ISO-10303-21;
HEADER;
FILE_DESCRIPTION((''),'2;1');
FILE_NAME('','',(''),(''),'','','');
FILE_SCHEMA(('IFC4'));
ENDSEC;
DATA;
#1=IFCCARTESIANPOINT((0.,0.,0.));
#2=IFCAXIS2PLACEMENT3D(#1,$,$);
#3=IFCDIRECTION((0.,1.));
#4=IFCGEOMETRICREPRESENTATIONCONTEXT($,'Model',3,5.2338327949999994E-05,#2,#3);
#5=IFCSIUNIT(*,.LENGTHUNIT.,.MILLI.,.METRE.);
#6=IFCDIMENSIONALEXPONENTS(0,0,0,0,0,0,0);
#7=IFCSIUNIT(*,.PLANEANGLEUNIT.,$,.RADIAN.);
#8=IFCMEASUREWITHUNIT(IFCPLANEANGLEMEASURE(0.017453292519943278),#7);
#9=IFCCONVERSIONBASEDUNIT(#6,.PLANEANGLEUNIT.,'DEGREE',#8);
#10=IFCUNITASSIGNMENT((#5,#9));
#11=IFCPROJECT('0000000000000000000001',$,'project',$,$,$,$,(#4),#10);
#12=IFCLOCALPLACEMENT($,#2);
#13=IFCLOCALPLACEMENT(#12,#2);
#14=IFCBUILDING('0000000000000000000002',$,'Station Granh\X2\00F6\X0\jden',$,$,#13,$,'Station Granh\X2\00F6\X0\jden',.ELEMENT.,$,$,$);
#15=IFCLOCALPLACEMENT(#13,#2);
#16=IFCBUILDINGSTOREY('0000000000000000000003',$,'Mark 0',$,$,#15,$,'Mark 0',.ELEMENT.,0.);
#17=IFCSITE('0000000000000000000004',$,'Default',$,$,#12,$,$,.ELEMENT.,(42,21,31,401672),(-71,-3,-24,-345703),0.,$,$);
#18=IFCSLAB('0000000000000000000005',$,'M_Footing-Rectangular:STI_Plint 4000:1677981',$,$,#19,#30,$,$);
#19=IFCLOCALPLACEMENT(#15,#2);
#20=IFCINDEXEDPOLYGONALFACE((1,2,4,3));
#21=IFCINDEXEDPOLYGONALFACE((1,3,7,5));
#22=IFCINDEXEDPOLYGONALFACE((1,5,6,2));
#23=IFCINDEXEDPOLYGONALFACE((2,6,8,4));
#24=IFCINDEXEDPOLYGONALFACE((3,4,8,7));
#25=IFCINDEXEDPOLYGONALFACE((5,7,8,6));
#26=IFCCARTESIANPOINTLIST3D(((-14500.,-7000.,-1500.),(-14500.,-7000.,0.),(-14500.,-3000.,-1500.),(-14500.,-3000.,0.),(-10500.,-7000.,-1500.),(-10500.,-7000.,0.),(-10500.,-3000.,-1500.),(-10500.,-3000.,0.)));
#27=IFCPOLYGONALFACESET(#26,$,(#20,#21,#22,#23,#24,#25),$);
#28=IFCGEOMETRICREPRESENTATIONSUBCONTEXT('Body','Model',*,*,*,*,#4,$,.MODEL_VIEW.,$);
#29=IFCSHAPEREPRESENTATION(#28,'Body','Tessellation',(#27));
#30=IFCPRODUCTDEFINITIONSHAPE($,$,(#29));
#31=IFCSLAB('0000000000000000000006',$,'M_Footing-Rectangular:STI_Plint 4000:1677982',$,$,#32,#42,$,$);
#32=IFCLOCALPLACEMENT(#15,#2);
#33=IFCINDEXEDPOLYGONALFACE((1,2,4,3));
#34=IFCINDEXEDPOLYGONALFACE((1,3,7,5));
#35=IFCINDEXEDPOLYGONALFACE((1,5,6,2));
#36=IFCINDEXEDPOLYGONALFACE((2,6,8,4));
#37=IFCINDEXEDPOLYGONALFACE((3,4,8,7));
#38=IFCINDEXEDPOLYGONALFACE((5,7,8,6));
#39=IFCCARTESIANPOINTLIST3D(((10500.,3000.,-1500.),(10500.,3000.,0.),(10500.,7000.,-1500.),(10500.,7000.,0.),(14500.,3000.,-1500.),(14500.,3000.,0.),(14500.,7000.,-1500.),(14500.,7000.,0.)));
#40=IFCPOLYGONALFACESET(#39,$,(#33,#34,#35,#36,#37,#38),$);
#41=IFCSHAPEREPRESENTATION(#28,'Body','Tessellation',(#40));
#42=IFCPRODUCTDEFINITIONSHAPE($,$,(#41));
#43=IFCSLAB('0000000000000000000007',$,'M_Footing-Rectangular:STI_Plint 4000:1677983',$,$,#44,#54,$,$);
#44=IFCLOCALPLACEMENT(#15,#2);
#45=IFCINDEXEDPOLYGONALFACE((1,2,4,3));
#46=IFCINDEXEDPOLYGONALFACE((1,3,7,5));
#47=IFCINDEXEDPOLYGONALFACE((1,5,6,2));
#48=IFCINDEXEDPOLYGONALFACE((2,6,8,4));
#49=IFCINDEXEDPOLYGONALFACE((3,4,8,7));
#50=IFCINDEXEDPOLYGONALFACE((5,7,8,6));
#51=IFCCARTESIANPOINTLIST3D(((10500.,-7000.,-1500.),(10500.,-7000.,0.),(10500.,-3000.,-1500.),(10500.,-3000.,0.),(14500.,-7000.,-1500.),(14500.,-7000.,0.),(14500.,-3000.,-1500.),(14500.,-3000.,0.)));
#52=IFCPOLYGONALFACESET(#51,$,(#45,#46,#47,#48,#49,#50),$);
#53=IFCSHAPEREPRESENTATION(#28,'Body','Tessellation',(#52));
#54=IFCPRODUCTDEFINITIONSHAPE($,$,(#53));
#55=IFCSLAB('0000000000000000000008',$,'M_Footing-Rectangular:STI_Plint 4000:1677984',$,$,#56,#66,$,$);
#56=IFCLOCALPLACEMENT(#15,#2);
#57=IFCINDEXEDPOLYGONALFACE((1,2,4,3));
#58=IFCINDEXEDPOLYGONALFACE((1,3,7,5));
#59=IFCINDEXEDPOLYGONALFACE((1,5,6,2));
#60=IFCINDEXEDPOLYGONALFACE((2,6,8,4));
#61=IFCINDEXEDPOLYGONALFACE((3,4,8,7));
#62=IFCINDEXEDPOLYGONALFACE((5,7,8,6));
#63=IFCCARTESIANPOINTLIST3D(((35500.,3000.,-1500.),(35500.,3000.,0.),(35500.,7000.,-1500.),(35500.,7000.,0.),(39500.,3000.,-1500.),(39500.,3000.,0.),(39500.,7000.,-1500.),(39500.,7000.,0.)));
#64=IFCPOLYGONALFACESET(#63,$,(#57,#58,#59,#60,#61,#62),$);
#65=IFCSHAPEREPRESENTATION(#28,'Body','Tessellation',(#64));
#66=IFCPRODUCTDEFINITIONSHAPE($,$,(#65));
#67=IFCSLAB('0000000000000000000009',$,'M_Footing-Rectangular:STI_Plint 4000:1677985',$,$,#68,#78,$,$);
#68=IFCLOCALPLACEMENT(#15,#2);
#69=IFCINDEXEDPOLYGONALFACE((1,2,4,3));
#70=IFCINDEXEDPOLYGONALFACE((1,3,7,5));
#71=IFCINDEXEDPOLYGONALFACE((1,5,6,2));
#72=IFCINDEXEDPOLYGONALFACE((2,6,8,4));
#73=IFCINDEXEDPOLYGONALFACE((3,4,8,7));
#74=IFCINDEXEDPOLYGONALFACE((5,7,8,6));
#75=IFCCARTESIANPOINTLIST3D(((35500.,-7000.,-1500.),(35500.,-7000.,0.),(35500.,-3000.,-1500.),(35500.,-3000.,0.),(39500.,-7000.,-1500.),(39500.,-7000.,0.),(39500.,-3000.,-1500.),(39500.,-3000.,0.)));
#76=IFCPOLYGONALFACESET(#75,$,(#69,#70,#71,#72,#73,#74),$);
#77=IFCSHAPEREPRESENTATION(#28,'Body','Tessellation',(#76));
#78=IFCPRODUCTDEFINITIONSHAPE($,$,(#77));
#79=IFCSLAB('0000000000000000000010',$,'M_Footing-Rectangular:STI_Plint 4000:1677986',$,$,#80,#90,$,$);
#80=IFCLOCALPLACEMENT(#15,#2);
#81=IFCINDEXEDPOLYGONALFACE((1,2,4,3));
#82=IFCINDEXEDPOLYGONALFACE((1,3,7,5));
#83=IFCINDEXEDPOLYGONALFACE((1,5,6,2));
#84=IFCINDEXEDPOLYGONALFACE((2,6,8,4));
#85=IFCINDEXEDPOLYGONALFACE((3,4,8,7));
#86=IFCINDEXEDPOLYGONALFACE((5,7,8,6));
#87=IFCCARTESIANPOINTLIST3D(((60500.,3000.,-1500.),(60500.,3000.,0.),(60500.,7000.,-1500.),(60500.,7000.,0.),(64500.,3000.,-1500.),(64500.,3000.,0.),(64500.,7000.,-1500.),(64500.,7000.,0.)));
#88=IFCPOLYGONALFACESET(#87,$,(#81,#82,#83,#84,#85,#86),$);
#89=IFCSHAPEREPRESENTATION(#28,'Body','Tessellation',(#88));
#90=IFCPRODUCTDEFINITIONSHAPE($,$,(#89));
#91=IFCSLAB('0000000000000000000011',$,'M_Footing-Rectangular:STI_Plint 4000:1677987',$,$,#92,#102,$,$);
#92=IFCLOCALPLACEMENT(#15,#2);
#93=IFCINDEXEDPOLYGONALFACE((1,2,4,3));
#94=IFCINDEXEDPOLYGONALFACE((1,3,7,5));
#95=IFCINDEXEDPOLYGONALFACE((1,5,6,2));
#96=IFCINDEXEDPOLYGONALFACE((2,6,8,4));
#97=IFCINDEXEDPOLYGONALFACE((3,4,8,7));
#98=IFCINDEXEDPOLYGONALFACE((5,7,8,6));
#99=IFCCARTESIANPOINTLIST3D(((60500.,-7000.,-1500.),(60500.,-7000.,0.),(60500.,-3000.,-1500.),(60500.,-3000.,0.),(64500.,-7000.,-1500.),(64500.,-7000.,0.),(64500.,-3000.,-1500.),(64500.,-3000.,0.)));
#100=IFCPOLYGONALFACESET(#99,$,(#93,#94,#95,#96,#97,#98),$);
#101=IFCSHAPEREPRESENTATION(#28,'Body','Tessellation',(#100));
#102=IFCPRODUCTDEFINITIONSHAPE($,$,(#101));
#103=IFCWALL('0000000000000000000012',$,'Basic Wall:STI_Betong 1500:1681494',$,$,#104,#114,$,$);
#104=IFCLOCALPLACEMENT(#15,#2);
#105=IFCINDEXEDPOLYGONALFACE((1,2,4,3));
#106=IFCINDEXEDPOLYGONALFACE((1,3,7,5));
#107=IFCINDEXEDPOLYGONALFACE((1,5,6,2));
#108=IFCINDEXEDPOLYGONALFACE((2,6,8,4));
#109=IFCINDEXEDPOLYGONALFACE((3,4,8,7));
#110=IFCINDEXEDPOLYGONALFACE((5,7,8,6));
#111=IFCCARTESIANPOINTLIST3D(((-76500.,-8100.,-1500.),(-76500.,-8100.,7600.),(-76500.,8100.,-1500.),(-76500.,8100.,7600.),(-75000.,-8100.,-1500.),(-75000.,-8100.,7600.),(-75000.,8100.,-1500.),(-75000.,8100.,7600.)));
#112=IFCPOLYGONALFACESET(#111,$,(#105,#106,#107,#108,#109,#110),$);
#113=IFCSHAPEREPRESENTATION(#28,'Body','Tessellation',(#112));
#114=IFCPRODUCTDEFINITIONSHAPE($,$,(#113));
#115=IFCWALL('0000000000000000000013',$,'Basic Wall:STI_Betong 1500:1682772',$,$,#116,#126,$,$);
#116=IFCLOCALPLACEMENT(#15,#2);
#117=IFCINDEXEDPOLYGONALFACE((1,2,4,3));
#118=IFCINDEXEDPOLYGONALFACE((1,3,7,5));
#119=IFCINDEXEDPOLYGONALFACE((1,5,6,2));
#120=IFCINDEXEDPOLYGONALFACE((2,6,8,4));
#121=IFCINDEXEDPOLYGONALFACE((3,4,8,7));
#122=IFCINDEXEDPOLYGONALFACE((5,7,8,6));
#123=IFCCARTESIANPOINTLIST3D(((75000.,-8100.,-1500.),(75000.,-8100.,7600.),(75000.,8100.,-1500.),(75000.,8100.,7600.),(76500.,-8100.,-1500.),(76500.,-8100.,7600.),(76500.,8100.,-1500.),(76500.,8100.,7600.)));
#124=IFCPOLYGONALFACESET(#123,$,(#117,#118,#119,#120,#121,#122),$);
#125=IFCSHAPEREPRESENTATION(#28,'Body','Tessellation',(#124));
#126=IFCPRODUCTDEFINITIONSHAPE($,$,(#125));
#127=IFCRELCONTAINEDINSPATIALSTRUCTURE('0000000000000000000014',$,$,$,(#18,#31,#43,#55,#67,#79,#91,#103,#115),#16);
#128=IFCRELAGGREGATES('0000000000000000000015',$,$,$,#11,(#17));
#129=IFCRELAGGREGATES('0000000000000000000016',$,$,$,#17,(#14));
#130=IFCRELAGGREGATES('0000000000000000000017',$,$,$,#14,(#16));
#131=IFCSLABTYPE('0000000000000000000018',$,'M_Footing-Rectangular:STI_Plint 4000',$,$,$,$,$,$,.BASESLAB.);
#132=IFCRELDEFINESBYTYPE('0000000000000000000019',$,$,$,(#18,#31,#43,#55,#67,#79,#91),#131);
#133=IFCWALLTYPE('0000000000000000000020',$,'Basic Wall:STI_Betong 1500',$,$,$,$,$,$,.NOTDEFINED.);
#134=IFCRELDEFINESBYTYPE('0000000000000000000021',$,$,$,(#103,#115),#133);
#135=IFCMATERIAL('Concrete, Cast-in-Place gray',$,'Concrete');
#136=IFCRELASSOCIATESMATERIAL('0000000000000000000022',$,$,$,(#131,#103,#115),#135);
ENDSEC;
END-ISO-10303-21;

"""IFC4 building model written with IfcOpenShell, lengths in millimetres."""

from ifc_helpers import new_model, entity, si_unit, converted_unit, direction, frame, origin, place, context, subcontext, project, spatial, indexed_curve, outline, extrude, material, type_object, element, save


model = new_model("IFC4")

# Units and contexts
model_context = context("Model", 3, precision=5.2338327949999994e-05, world=origin(), true_north=direction((0.0, 1.0)))
body_context = subcontext(model_context, "Body", "Model", "MODEL_VIEW")
ifc_project = project(units=[si_unit("LENGTHUNIT", "METRE", prefix="MILLI"), converted_unit("PLANEANGLEUNIT", "DEGREE", entity("IfcPlaneAngleMeasure", 0.017453292519943278), si_unit("PLANEANGLEUNIT", "RADIAN"), dimensions=[0, 0, 0, 0, 0, 0, 0])], contexts=[model_context])

# Site, building, storey
site_placement = place(None, origin())
site = spatial("IfcSite", under=ifc_project, at=site_placement, Name="Default", CompositionType="ELEMENT", RefLatitude=(42, 21, 31, 401672), RefLongitude=(-71, -3, -24, -345703), RefElevation=0.0)
building_placement = place(site_placement, origin())
building = spatial("IfcBuilding", under=site, at=building_placement, Name="Station Granhöjden", LongName="Station Granhöjden", CompositionType="ELEMENT")
storey_placement = place(building_placement, origin())
storey = spatial("IfcBuildingStorey", under=building, at=storey_placement, Name="Mark 0", LongName="Mark 0", CompositionType="ELEMENT", Elevation=0.0)

# Shared definitions
ifc_material = material(Name="Concrete, Cast-in-Place gray", Category="Concrete")

# Slabs
slab_type = type_object("IfcSlabType", Name="M_Footing-Rectangular:STI_Plint 4000", PredefinedType="BASESLAB", material=ifc_material)
slab_1_placement = place(storey_placement, origin())
element("IfcSlab", 1, at=slab_1_placement, inside=storey, type_object=slab_type, Name="M_Footing-Rectangular:STI_Plint 4000:1677981", context=body_context, shape_type="SweptSolid", body=[
    extrude(outline(indexed_curve([(-2000.0, -2000.0), (2000.0, -2000.0), (2000.0, 2000.0), (-2000.0, 2000.0), (-2000.0, -2000.0)], self_intersect=False)), frame((-12500.0, -5000.0, -1500.0), z_axis=(0.0, 0.0, 1.0), x_axis=(-1.0, 0.0, 0.0)), (0.0, 0.0, 1.0), 1500.0),
])
slab_2_placement = place(storey_placement, origin())
element("IfcSlab", 2, at=slab_2_placement, inside=storey, type_object=slab_type, Name="M_Footing-Rectangular:STI_Plint 4000:1677982", context=body_context, shape_type="SweptSolid", body=[
    extrude(outline(indexed_curve([(-2000.0, -2000.0), (2000.0, -2000.0), (2000.0, 2000.0), (-2000.0, 2000.0), (-2000.0, -2000.0)], self_intersect=False)), frame((12500.0, 5000.0, -1500.0), z_axis=(0.0, 0.0, 1.0), x_axis=(-1.0, 0.0, 0.0)), (0.0, 0.0, 1.0), 1500.0),
])
slab_3_placement = place(storey_placement, origin())
element("IfcSlab", 3, at=slab_3_placement, inside=storey, type_object=slab_type, Name="M_Footing-Rectangular:STI_Plint 4000:1677983", context=body_context, shape_type="SweptSolid", body=[
    extrude(outline(indexed_curve([(-2000.0, -2000.0), (2000.0, -2000.0), (2000.0, 2000.0), (-2000.0, 2000.0), (-2000.0, -2000.0)], self_intersect=False)), frame((12500.0, -5000.0, -1500.0), z_axis=(0.0, 0.0, 1.0), x_axis=(-1.0, 0.0, 0.0)), (0.0, 0.0, 1.0), 1500.0),
])
slab_4_placement = place(storey_placement, origin())
element("IfcSlab", 4, at=slab_4_placement, inside=storey, type_object=slab_type, Name="M_Footing-Rectangular:STI_Plint 4000:1677984", context=body_context, shape_type="SweptSolid", body=[
    extrude(outline(indexed_curve([(-2000.0, -2000.0), (2000.0, -2000.0), (2000.0, 2000.0), (-2000.0, 2000.0), (-2000.0, -2000.0)], self_intersect=False)), frame((37500.0, 5000.0, -1500.0), z_axis=(0.0, 0.0, 1.0), x_axis=(-1.0, 0.0, 0.0)), (0.0, 0.0, 1.0), 1500.0),
])
slab_5_placement = place(storey_placement, origin())
element("IfcSlab", 5, at=slab_5_placement, inside=storey, type_object=slab_type, Name="M_Footing-Rectangular:STI_Plint 4000:1677985", context=body_context, shape_type="SweptSolid", body=[
    extrude(outline(indexed_curve([(-2000.0, -2000.0), (2000.0, -2000.0), (2000.0, 2000.0), (-2000.0, 2000.0), (-2000.0, -2000.0)], self_intersect=False)), frame((37500.0, -5000.0, -1500.0), z_axis=(0.0, 0.0, 1.0), x_axis=(-1.0, 0.0, 0.0)), (0.0, 0.0, 1.0), 1500.0),
])
slab_6_placement = place(storey_placement, origin())
element("IfcSlab", 6, at=slab_6_placement, inside=storey, type_object=slab_type, Name="M_Footing-Rectangular:STI_Plint 4000:1677986", context=body_context, shape_type="SweptSolid", body=[
    extrude(outline(indexed_curve([(-2000.0, -2000.0), (2000.0, -2000.0), (2000.0, 2000.0), (-2000.0, 2000.0), (-2000.0, -2000.0)], self_intersect=False)), frame((62500.0, 5000.0, -1500.0), z_axis=(0.0, 0.0, 1.0), x_axis=(-1.0, 0.0, 0.0)), (0.0, 0.0, 1.0), 1500.0),
])
slab_7_placement = place(storey_placement, origin())
element("IfcSlab", 7, at=slab_7_placement, inside=storey, type_object=slab_type, Name="M_Footing-Rectangular:STI_Plint 4000:1677987", context=body_context, shape_type="SweptSolid", body=[
    extrude(outline(indexed_curve([(-2000.0, -2000.0), (2000.0, -2000.0), (2000.0, 2000.0), (-2000.0, 2000.0), (-2000.0, -2000.0)], self_intersect=False)), frame((62500.0, -5000.0, -1500.0), z_axis=(0.0, 0.0, 1.0), x_axis=(-1.0, 0.0, 0.0)), (0.0, 0.0, 1.0), 1500.0),
])

# Walls
wall_type = type_object("IfcWallType", Name="Basic Wall:STI_Betong 1500", PredefinedType="NOTDEFINED")
wall_1_placement = place(storey_placement, frame((-75750.0, 8100.0, -1500.0), z_axis=(0.0, 0.0, 1.0), x_axis=(0.0, -1.0, 0.0)))
element("IfcWall", 8, at=wall_1_placement, inside=storey, type_object=wall_type, material=ifc_material, Name="Basic Wall:STI_Betong 1500:1681494", context=body_context, shape_type="SweptSolid", body=[
    extrude(outline(indexed_curve([(16200.0, 750.0), (0.0, 750.0), (0.0, -750.0), (16200.0, -750.0), (16200.0, 750.0)], self_intersect=False)), origin(), (0.0, 0.0, 1.0), 9100.0),
])
wall_2_placement = place(storey_placement, frame((75750.0, 8100.0, -1500.0), z_axis=(0.0, 0.0, 1.0), x_axis=(0.0, -1.0, 0.0)))
element("IfcWall", 9, at=wall_2_placement, inside=storey, type_object=wall_type, material=ifc_material, Name="Basic Wall:STI_Betong 1500:1682772", context=body_context, shape_type="SweptSolid", body=[
    extrude(outline(indexed_curve([(16200.0, 750.0), (0.0, 750.0), (0.0, -750.0), (16200.0, -750.0), (16200.0, 750.0)], self_intersect=False)), origin(), (0.0, 0.0, 1.0), 9100.0),
])

save(model, "model.ifc")
